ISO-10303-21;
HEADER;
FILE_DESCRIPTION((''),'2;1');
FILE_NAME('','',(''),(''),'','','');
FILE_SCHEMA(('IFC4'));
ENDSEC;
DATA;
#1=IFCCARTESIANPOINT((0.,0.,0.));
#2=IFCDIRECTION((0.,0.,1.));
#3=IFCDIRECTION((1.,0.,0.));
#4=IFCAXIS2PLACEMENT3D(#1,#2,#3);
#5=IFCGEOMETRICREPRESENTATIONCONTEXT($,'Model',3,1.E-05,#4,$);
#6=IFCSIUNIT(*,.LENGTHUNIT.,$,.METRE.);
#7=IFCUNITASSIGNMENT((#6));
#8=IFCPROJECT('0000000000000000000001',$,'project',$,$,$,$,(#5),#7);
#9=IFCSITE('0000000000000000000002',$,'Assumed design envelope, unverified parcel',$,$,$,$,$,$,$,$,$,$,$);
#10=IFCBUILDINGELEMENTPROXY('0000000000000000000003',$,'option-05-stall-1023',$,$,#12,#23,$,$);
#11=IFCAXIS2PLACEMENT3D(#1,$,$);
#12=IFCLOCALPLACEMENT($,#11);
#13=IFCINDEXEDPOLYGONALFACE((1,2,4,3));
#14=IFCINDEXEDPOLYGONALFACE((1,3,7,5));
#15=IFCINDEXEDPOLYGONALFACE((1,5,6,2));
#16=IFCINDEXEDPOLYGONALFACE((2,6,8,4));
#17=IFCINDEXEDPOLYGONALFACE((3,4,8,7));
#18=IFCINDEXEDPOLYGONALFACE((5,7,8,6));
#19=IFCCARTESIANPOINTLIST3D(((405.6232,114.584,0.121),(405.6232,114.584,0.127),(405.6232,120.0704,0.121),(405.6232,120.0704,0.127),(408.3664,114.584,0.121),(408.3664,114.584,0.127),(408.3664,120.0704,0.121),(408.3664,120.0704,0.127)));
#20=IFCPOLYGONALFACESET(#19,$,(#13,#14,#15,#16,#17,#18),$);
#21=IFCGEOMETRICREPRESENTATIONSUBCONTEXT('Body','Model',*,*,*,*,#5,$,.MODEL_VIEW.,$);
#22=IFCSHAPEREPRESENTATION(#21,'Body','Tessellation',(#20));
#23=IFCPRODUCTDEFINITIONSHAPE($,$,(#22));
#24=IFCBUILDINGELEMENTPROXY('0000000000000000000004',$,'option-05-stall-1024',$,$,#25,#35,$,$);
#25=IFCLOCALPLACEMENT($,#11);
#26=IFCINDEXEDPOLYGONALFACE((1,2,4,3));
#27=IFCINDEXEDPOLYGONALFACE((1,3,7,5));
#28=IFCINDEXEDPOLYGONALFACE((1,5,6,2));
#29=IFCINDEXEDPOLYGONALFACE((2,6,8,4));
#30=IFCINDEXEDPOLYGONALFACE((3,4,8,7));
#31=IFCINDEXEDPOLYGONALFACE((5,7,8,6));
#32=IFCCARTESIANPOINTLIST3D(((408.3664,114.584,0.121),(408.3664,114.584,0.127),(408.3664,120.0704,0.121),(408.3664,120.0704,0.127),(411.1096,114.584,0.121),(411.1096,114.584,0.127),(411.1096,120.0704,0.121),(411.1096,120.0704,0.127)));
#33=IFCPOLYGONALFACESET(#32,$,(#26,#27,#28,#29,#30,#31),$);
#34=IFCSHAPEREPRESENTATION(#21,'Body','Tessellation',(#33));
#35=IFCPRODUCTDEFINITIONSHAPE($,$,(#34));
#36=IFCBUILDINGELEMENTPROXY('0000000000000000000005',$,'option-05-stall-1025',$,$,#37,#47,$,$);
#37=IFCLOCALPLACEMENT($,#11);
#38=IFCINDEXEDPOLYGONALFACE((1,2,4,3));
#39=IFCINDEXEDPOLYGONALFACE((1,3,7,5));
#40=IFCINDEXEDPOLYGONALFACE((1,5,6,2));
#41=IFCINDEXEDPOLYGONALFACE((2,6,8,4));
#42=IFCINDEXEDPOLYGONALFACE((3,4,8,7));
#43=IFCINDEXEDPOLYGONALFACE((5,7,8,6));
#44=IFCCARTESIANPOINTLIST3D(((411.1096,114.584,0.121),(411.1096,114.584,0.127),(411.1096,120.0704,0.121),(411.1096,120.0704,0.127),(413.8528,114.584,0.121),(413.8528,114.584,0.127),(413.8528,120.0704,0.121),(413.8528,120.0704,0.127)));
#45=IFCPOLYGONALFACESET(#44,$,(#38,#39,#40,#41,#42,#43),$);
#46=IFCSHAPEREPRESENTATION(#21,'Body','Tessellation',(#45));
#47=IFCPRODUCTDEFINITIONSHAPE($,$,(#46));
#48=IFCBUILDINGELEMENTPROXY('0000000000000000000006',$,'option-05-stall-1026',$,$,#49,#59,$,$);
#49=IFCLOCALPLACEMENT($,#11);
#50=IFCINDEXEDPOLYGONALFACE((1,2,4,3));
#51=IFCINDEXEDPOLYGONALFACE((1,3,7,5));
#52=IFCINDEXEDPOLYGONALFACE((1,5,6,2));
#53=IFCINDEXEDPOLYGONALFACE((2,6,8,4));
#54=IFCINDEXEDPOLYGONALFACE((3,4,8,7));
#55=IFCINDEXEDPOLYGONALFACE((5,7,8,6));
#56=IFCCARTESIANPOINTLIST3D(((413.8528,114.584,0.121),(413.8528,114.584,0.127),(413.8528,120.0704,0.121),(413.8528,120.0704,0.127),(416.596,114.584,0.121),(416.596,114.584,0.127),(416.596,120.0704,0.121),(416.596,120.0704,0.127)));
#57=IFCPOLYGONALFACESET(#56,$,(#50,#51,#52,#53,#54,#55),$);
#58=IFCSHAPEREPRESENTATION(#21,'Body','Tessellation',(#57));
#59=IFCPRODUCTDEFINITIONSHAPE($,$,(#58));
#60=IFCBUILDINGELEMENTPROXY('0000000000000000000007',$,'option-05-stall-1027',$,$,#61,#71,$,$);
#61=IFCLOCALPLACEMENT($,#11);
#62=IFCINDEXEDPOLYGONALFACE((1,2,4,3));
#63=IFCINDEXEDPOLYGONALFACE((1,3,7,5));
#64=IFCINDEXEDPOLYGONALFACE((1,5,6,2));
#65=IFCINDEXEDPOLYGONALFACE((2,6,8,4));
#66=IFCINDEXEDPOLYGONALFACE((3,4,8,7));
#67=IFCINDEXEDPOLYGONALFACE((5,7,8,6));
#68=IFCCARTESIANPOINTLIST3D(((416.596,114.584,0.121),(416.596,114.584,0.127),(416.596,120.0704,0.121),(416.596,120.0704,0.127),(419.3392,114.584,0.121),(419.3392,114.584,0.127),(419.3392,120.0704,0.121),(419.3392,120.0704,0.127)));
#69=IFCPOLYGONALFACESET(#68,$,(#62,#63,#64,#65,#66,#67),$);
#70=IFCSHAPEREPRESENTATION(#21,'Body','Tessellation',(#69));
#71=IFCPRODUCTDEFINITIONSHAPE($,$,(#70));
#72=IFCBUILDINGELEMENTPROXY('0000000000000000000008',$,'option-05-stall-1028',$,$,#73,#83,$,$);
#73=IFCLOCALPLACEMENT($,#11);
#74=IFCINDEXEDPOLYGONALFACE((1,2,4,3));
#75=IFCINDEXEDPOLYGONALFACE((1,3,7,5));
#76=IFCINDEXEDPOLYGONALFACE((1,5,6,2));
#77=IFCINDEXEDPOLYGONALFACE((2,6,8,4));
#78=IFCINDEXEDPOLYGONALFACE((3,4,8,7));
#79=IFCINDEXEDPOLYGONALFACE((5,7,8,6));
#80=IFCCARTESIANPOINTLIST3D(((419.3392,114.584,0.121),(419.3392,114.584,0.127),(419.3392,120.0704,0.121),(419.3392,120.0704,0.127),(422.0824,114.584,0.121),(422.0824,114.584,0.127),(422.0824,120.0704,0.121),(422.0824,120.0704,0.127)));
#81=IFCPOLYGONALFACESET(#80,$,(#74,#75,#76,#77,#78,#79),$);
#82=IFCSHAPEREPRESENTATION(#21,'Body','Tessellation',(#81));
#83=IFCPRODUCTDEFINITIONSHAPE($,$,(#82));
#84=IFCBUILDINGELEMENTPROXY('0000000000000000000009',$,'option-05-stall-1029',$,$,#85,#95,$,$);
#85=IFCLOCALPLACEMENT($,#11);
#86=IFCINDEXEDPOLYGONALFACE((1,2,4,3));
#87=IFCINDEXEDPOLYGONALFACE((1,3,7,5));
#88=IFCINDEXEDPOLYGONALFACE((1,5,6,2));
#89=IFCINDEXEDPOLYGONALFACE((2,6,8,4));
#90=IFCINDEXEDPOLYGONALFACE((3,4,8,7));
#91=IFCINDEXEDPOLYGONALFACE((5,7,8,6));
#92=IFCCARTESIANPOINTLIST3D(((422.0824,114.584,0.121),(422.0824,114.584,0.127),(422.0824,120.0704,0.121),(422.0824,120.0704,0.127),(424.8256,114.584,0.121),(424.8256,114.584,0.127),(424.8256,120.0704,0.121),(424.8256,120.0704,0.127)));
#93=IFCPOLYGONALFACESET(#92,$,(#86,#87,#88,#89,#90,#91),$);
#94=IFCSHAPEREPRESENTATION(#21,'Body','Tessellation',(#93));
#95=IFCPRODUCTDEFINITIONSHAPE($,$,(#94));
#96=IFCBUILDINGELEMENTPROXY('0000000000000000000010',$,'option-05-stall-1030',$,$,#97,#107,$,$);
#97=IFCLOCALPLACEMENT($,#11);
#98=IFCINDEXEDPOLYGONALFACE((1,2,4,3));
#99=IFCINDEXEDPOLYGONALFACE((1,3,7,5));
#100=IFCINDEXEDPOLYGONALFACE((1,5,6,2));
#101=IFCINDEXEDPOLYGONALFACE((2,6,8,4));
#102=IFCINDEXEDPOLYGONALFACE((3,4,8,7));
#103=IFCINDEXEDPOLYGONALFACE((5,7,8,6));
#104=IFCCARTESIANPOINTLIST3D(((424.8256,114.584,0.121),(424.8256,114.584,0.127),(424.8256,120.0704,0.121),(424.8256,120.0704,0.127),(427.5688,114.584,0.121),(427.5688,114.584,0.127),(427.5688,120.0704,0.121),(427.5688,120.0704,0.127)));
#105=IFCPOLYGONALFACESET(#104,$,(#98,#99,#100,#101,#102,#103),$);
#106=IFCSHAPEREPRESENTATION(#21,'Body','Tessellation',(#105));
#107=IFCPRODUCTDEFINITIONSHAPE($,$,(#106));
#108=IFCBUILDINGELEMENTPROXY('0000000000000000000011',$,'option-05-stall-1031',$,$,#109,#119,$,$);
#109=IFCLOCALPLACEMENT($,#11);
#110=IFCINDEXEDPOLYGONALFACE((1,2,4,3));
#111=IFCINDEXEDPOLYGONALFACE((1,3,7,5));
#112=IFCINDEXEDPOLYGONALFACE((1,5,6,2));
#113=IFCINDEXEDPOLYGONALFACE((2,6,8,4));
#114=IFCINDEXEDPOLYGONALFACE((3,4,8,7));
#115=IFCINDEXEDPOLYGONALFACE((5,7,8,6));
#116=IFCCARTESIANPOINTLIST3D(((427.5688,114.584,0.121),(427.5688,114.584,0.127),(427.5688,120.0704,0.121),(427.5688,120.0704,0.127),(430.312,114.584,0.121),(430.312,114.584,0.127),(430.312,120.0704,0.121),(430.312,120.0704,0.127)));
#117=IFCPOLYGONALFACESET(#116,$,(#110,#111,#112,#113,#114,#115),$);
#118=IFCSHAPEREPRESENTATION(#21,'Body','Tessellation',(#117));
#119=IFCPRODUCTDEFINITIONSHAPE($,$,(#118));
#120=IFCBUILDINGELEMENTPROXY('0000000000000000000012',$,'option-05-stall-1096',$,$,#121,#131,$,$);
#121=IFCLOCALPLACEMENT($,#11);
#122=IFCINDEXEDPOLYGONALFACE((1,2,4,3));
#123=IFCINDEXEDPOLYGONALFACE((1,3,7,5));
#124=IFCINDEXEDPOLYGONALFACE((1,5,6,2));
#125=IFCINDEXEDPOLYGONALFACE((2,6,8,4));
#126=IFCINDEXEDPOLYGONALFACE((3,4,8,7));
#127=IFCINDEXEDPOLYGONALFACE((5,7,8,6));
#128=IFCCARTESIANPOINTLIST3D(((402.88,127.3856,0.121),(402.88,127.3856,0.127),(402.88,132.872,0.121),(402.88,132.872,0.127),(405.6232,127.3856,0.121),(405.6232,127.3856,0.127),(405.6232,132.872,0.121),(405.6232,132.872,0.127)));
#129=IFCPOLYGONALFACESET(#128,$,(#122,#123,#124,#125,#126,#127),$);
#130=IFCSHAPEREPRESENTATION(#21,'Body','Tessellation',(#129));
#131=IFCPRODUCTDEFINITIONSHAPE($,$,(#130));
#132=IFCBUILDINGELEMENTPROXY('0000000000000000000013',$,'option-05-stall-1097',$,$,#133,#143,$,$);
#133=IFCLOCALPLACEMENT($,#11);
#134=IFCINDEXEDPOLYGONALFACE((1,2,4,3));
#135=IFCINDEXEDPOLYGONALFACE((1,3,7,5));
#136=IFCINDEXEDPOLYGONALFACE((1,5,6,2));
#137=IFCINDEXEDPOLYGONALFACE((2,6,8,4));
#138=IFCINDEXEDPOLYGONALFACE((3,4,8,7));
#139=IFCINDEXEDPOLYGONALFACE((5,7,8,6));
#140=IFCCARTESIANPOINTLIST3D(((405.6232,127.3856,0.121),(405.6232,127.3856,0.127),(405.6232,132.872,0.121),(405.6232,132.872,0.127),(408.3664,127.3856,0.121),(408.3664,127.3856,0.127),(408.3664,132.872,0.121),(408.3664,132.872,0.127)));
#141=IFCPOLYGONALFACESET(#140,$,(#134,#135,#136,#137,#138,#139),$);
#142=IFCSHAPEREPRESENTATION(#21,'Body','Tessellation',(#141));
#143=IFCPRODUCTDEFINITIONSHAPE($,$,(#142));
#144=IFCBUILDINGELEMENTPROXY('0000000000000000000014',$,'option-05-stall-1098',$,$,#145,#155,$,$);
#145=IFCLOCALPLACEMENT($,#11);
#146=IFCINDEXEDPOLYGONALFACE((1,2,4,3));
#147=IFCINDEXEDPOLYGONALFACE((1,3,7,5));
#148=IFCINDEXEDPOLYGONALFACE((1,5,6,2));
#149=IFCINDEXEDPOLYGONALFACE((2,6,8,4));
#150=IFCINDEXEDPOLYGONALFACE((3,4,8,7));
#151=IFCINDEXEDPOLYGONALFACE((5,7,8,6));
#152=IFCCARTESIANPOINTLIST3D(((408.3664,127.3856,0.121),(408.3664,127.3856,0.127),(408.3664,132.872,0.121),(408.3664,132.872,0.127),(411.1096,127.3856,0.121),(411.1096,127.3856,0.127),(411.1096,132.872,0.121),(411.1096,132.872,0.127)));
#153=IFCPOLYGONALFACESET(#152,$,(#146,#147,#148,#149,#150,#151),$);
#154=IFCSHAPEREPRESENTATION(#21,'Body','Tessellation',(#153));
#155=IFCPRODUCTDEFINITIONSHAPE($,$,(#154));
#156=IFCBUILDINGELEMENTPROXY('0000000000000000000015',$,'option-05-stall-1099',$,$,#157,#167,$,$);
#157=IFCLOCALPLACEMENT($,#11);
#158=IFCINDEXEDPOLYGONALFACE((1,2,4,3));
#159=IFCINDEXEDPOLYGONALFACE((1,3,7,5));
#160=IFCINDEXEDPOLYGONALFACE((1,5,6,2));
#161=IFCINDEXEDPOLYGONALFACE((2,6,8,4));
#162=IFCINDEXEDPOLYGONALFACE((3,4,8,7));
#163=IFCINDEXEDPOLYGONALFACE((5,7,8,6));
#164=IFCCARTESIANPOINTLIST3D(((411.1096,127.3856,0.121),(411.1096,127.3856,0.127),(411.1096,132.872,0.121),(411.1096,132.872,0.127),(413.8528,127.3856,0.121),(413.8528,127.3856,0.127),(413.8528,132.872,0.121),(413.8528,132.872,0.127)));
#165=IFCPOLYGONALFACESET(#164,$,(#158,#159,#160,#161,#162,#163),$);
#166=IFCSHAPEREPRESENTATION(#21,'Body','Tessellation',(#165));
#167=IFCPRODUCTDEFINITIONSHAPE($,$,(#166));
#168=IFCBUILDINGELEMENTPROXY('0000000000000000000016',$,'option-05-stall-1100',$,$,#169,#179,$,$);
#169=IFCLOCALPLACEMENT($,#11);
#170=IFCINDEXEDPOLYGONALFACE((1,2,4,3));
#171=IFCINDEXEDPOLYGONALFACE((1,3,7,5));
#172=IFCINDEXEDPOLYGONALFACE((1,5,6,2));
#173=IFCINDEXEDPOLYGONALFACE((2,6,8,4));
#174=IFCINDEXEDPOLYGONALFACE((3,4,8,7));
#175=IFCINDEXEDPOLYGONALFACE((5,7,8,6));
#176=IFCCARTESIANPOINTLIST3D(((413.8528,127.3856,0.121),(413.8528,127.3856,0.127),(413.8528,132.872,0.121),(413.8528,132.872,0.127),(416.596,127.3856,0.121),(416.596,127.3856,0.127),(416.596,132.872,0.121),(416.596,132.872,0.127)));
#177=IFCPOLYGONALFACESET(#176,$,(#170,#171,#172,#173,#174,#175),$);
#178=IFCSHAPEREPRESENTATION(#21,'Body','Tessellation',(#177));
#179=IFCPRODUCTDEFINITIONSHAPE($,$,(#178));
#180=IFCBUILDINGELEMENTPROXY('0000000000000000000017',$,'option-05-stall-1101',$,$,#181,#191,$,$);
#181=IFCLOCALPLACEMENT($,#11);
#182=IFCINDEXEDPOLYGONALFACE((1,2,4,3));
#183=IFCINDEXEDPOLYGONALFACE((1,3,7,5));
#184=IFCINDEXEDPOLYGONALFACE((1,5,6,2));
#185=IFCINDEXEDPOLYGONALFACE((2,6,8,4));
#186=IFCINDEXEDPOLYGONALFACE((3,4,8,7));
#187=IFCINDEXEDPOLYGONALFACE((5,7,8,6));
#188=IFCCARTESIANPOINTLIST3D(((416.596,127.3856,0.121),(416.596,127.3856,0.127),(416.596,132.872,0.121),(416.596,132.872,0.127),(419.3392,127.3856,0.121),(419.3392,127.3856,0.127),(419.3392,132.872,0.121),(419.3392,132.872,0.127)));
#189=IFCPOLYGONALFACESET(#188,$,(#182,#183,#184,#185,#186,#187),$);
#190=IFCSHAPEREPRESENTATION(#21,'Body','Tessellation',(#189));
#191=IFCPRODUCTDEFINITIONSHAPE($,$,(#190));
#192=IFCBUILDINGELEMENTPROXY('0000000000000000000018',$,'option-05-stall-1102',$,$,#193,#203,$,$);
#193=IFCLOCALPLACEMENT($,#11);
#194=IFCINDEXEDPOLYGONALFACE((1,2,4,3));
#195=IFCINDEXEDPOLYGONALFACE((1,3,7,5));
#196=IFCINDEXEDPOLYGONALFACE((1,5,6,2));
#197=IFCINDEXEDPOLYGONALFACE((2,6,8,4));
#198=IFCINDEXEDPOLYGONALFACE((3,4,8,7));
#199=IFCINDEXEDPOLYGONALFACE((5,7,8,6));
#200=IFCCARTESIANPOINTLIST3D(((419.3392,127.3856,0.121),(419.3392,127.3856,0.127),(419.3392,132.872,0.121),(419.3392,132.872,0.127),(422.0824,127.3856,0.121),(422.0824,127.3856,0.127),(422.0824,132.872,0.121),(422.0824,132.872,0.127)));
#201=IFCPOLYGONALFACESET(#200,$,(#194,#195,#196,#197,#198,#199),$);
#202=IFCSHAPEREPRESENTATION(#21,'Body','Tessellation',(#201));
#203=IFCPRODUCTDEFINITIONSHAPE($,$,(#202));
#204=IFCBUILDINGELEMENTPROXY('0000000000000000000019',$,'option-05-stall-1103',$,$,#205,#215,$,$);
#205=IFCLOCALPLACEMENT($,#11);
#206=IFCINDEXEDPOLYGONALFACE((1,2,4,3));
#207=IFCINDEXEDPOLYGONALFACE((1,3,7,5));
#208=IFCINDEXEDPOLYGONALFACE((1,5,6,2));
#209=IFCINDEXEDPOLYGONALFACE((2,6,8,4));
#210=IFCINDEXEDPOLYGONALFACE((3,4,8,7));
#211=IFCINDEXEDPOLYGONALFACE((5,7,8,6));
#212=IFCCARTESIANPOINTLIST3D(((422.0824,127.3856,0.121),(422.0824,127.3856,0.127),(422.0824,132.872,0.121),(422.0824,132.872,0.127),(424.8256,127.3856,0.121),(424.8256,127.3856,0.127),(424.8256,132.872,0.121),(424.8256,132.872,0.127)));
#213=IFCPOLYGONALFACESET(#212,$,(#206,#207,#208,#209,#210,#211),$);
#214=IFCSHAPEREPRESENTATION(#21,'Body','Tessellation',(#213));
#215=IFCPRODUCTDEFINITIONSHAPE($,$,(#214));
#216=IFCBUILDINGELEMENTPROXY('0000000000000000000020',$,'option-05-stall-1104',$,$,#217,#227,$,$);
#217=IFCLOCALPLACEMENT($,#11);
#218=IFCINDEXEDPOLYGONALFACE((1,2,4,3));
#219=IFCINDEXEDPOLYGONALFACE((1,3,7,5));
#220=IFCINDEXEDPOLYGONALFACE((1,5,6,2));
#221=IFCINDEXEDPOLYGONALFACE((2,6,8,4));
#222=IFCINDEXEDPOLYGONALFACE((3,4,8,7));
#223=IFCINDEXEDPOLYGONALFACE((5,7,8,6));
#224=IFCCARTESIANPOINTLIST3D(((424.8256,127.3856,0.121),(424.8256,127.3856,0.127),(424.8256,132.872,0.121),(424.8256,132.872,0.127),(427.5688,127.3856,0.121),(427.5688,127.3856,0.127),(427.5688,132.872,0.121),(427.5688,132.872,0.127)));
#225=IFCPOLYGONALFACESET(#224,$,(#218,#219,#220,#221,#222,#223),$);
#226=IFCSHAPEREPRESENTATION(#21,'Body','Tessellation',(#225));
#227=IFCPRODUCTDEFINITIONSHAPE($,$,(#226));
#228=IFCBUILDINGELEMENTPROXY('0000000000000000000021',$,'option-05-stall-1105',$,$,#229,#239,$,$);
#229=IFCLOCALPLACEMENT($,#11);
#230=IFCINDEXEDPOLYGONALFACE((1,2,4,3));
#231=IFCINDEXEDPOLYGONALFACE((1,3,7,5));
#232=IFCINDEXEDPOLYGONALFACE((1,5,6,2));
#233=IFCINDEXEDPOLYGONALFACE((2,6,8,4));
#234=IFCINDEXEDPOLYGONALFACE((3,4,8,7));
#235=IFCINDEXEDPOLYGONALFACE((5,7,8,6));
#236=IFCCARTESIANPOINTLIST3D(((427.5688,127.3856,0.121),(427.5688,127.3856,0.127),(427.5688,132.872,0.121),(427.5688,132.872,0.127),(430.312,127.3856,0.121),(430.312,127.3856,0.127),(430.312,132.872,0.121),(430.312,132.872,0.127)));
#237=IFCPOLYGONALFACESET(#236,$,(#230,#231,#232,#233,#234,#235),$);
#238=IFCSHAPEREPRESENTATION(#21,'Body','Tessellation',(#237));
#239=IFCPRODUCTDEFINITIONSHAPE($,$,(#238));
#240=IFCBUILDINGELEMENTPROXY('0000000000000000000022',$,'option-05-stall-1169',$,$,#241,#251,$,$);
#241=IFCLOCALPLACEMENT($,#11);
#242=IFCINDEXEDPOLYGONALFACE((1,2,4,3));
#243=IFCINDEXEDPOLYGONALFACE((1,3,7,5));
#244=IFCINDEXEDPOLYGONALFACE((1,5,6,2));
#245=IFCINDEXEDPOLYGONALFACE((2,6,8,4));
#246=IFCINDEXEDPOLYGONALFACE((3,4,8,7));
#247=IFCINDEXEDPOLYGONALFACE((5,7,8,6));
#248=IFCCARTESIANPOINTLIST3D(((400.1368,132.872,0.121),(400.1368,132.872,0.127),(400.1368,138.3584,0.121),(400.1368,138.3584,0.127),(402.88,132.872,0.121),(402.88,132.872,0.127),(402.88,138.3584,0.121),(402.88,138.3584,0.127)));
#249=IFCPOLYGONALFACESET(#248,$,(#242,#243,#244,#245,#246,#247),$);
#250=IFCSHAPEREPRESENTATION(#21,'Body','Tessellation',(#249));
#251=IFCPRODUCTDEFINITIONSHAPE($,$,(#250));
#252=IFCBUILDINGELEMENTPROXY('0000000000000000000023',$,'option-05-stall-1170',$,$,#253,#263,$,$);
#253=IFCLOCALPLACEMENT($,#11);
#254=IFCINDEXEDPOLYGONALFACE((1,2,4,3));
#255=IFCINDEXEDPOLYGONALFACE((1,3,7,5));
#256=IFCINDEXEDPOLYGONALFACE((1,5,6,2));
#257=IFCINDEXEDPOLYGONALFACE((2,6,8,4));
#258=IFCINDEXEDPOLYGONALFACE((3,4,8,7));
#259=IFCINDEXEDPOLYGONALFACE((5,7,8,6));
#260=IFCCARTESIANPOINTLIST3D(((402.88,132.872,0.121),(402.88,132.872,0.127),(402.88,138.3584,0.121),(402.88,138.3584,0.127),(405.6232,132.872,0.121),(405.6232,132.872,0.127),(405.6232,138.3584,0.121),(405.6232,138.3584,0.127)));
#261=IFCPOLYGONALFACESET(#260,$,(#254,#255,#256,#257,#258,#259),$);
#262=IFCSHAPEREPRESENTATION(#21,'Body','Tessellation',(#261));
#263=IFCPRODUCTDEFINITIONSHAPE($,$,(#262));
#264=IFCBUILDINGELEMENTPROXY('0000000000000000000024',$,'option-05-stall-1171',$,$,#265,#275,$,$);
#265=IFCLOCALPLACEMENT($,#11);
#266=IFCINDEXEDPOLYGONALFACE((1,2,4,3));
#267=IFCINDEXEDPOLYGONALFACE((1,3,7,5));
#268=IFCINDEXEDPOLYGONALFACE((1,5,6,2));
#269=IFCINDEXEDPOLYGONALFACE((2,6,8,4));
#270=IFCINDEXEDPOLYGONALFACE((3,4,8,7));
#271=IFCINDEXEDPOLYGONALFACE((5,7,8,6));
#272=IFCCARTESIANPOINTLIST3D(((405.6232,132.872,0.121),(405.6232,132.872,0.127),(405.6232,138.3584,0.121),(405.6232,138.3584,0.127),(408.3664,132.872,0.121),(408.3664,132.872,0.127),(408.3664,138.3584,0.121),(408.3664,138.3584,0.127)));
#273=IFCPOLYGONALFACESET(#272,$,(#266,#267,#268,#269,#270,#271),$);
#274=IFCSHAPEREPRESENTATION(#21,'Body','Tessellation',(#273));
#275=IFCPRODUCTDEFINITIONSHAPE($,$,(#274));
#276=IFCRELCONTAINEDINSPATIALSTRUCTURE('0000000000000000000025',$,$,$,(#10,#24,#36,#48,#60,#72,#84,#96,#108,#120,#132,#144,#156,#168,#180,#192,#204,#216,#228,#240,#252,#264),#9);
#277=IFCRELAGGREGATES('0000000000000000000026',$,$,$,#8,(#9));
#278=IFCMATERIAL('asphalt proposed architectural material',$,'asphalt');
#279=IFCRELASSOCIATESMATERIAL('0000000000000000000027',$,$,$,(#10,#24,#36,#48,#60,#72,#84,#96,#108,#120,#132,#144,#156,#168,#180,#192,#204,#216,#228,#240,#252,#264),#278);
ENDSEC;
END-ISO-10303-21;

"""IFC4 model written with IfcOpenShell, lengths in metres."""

from ifc_helpers import new_model, si_unit, frame, origin_with_axes, place, context, subcontext, project, spatial, rectangle, extrude, material, element, save


model = new_model("IFC4")

# Units and contexts
model_context = context("Model", 3, precision=1e-05, world=origin_with_axes())
body_context = subcontext(model_context, "Body", "Model", "MODEL_VIEW")
ifc_project = project(units=[si_unit("LENGTHUNIT", "METRE")], contexts=[model_context])

# Site
site = spatial("IfcSite", under=ifc_project, Name="Assumed design envelope, unverified parcel")

# Building element proxies
ifc_material = material(Name="asphalt proposed architectural material", Category="asphalt")
for number, where, z_axis, x_axis, name in (
    (1, (406.9948, 117.3272, 0.121), (0.0, 0.0, 1.0), (1.0, 0.0, 0.0), "option-05-stall-1023"),
    (2, (409.738, 117.3272, 0.121), (0.0, 0.0, 1.0), (1.0, 0.0, 0.0), "option-05-stall-1024"),
    (3, (412.4812, 117.3272, 0.121), (0.0, 0.0, 1.0), (1.0, 0.0, 0.0), "option-05-stall-1025"),
    (4, (415.2244, 117.3272, 0.121), (0.0, 0.0, 1.0), (1.0, 0.0, 0.0), "option-05-stall-1026"),
    (5, (417.9676, 117.3272, 0.121), (0.0, 0.0, 1.0), (1.0, 0.0, 0.0), "option-05-stall-1027"),
    (6, (420.7108, 117.3272, 0.121), (0.0, 0.0, 1.0), (1.0, 0.0, 0.0), "option-05-stall-1028"),
    (7, (423.454, 117.3272, 0.121), (0.0, 0.0, 1.0), (1.0, 0.0, 0.0), "option-05-stall-1029"),
    (8, (426.1972, 117.3272, 0.121), (0.0, 0.0, 1.0), (1.0, 0.0, 0.0), "option-05-stall-1030"),
    (9, (428.9404, 117.3272, 0.121), (0.0, 0.0, 1.0), (1.0, 0.0, 0.0), "option-05-stall-1031"),
    (10, (404.2516, 130.1288, 0.121), (0.0, 0.0, 1.0), (1.0, 0.0, 0.0), "option-05-stall-1096"),
    (11, (406.9948, 130.1288, 0.121), (0.0, 0.0, 1.0), (1.0, 0.0, 0.0), "option-05-stall-1097"),
    (12, (409.738, 130.1288, 0.121), (0.0, 0.0, 1.0), (1.0, 0.0, 0.0), "option-05-stall-1098"),
    (13, (412.4812, 130.1288, 0.121), (0.0, 0.0, 1.0), (1.0, 0.0, 0.0), "option-05-stall-1099"),
    (14, (415.2244, 130.1288, 0.121), (0.0, 0.0, 1.0), (1.0, 0.0, 0.0), "option-05-stall-1100"),
    (15, (417.9676, 130.1288, 0.121), (0.0, 0.0, 1.0), (1.0, 0.0, 0.0), "option-05-stall-1101"),
    (16, (420.7108, 130.1288, 0.121), (0.0, 0.0, 1.0), (1.0, 0.0, 0.0), "option-05-stall-1102"),
    (17, (423.454, 130.1288, 0.121), (0.0, 0.0, 1.0), (1.0, 0.0, 0.0), "option-05-stall-1103"),
    (18, (426.1972, 130.1288, 0.121), (0.0, 0.0, 1.0), (1.0, 0.0, 0.0), "option-05-stall-1104"),
    (19, (428.9404, 130.1288, 0.121), (0.0, 0.0, 1.0), (1.0, 0.0, 0.0), "option-05-stall-1105"),
    (20, (401.5084, 135.6152, 0.121), (0.0, 0.0, 1.0), (1.0, 0.0, 0.0), "option-05-stall-1169"),
    (21, (404.2516, 135.6152, 0.121), (0.0, 0.0, 1.0), (1.0, 0.0, 0.0), "option-05-stall-1170"),
    (22, (406.9948, 135.6152, 0.121), (0.0, 0.0, 1.0), (1.0, 0.0, 0.0), "option-05-stall-1171"),
):
    element("IfcBuildingElementProxy", number, at=place(None, frame(where, z_axis=z_axis, x_axis=x_axis)), inside=site, material=ifc_material, Name=name, context=body_context, shape_type="SweptSolid", body=[
        extrude(rectangle(XDim=2.7432, YDim=5.4864), origin_with_axes(), (0.0, 0.0, 1.0), 0.006),
    ])

save(model, "model.ifc")
